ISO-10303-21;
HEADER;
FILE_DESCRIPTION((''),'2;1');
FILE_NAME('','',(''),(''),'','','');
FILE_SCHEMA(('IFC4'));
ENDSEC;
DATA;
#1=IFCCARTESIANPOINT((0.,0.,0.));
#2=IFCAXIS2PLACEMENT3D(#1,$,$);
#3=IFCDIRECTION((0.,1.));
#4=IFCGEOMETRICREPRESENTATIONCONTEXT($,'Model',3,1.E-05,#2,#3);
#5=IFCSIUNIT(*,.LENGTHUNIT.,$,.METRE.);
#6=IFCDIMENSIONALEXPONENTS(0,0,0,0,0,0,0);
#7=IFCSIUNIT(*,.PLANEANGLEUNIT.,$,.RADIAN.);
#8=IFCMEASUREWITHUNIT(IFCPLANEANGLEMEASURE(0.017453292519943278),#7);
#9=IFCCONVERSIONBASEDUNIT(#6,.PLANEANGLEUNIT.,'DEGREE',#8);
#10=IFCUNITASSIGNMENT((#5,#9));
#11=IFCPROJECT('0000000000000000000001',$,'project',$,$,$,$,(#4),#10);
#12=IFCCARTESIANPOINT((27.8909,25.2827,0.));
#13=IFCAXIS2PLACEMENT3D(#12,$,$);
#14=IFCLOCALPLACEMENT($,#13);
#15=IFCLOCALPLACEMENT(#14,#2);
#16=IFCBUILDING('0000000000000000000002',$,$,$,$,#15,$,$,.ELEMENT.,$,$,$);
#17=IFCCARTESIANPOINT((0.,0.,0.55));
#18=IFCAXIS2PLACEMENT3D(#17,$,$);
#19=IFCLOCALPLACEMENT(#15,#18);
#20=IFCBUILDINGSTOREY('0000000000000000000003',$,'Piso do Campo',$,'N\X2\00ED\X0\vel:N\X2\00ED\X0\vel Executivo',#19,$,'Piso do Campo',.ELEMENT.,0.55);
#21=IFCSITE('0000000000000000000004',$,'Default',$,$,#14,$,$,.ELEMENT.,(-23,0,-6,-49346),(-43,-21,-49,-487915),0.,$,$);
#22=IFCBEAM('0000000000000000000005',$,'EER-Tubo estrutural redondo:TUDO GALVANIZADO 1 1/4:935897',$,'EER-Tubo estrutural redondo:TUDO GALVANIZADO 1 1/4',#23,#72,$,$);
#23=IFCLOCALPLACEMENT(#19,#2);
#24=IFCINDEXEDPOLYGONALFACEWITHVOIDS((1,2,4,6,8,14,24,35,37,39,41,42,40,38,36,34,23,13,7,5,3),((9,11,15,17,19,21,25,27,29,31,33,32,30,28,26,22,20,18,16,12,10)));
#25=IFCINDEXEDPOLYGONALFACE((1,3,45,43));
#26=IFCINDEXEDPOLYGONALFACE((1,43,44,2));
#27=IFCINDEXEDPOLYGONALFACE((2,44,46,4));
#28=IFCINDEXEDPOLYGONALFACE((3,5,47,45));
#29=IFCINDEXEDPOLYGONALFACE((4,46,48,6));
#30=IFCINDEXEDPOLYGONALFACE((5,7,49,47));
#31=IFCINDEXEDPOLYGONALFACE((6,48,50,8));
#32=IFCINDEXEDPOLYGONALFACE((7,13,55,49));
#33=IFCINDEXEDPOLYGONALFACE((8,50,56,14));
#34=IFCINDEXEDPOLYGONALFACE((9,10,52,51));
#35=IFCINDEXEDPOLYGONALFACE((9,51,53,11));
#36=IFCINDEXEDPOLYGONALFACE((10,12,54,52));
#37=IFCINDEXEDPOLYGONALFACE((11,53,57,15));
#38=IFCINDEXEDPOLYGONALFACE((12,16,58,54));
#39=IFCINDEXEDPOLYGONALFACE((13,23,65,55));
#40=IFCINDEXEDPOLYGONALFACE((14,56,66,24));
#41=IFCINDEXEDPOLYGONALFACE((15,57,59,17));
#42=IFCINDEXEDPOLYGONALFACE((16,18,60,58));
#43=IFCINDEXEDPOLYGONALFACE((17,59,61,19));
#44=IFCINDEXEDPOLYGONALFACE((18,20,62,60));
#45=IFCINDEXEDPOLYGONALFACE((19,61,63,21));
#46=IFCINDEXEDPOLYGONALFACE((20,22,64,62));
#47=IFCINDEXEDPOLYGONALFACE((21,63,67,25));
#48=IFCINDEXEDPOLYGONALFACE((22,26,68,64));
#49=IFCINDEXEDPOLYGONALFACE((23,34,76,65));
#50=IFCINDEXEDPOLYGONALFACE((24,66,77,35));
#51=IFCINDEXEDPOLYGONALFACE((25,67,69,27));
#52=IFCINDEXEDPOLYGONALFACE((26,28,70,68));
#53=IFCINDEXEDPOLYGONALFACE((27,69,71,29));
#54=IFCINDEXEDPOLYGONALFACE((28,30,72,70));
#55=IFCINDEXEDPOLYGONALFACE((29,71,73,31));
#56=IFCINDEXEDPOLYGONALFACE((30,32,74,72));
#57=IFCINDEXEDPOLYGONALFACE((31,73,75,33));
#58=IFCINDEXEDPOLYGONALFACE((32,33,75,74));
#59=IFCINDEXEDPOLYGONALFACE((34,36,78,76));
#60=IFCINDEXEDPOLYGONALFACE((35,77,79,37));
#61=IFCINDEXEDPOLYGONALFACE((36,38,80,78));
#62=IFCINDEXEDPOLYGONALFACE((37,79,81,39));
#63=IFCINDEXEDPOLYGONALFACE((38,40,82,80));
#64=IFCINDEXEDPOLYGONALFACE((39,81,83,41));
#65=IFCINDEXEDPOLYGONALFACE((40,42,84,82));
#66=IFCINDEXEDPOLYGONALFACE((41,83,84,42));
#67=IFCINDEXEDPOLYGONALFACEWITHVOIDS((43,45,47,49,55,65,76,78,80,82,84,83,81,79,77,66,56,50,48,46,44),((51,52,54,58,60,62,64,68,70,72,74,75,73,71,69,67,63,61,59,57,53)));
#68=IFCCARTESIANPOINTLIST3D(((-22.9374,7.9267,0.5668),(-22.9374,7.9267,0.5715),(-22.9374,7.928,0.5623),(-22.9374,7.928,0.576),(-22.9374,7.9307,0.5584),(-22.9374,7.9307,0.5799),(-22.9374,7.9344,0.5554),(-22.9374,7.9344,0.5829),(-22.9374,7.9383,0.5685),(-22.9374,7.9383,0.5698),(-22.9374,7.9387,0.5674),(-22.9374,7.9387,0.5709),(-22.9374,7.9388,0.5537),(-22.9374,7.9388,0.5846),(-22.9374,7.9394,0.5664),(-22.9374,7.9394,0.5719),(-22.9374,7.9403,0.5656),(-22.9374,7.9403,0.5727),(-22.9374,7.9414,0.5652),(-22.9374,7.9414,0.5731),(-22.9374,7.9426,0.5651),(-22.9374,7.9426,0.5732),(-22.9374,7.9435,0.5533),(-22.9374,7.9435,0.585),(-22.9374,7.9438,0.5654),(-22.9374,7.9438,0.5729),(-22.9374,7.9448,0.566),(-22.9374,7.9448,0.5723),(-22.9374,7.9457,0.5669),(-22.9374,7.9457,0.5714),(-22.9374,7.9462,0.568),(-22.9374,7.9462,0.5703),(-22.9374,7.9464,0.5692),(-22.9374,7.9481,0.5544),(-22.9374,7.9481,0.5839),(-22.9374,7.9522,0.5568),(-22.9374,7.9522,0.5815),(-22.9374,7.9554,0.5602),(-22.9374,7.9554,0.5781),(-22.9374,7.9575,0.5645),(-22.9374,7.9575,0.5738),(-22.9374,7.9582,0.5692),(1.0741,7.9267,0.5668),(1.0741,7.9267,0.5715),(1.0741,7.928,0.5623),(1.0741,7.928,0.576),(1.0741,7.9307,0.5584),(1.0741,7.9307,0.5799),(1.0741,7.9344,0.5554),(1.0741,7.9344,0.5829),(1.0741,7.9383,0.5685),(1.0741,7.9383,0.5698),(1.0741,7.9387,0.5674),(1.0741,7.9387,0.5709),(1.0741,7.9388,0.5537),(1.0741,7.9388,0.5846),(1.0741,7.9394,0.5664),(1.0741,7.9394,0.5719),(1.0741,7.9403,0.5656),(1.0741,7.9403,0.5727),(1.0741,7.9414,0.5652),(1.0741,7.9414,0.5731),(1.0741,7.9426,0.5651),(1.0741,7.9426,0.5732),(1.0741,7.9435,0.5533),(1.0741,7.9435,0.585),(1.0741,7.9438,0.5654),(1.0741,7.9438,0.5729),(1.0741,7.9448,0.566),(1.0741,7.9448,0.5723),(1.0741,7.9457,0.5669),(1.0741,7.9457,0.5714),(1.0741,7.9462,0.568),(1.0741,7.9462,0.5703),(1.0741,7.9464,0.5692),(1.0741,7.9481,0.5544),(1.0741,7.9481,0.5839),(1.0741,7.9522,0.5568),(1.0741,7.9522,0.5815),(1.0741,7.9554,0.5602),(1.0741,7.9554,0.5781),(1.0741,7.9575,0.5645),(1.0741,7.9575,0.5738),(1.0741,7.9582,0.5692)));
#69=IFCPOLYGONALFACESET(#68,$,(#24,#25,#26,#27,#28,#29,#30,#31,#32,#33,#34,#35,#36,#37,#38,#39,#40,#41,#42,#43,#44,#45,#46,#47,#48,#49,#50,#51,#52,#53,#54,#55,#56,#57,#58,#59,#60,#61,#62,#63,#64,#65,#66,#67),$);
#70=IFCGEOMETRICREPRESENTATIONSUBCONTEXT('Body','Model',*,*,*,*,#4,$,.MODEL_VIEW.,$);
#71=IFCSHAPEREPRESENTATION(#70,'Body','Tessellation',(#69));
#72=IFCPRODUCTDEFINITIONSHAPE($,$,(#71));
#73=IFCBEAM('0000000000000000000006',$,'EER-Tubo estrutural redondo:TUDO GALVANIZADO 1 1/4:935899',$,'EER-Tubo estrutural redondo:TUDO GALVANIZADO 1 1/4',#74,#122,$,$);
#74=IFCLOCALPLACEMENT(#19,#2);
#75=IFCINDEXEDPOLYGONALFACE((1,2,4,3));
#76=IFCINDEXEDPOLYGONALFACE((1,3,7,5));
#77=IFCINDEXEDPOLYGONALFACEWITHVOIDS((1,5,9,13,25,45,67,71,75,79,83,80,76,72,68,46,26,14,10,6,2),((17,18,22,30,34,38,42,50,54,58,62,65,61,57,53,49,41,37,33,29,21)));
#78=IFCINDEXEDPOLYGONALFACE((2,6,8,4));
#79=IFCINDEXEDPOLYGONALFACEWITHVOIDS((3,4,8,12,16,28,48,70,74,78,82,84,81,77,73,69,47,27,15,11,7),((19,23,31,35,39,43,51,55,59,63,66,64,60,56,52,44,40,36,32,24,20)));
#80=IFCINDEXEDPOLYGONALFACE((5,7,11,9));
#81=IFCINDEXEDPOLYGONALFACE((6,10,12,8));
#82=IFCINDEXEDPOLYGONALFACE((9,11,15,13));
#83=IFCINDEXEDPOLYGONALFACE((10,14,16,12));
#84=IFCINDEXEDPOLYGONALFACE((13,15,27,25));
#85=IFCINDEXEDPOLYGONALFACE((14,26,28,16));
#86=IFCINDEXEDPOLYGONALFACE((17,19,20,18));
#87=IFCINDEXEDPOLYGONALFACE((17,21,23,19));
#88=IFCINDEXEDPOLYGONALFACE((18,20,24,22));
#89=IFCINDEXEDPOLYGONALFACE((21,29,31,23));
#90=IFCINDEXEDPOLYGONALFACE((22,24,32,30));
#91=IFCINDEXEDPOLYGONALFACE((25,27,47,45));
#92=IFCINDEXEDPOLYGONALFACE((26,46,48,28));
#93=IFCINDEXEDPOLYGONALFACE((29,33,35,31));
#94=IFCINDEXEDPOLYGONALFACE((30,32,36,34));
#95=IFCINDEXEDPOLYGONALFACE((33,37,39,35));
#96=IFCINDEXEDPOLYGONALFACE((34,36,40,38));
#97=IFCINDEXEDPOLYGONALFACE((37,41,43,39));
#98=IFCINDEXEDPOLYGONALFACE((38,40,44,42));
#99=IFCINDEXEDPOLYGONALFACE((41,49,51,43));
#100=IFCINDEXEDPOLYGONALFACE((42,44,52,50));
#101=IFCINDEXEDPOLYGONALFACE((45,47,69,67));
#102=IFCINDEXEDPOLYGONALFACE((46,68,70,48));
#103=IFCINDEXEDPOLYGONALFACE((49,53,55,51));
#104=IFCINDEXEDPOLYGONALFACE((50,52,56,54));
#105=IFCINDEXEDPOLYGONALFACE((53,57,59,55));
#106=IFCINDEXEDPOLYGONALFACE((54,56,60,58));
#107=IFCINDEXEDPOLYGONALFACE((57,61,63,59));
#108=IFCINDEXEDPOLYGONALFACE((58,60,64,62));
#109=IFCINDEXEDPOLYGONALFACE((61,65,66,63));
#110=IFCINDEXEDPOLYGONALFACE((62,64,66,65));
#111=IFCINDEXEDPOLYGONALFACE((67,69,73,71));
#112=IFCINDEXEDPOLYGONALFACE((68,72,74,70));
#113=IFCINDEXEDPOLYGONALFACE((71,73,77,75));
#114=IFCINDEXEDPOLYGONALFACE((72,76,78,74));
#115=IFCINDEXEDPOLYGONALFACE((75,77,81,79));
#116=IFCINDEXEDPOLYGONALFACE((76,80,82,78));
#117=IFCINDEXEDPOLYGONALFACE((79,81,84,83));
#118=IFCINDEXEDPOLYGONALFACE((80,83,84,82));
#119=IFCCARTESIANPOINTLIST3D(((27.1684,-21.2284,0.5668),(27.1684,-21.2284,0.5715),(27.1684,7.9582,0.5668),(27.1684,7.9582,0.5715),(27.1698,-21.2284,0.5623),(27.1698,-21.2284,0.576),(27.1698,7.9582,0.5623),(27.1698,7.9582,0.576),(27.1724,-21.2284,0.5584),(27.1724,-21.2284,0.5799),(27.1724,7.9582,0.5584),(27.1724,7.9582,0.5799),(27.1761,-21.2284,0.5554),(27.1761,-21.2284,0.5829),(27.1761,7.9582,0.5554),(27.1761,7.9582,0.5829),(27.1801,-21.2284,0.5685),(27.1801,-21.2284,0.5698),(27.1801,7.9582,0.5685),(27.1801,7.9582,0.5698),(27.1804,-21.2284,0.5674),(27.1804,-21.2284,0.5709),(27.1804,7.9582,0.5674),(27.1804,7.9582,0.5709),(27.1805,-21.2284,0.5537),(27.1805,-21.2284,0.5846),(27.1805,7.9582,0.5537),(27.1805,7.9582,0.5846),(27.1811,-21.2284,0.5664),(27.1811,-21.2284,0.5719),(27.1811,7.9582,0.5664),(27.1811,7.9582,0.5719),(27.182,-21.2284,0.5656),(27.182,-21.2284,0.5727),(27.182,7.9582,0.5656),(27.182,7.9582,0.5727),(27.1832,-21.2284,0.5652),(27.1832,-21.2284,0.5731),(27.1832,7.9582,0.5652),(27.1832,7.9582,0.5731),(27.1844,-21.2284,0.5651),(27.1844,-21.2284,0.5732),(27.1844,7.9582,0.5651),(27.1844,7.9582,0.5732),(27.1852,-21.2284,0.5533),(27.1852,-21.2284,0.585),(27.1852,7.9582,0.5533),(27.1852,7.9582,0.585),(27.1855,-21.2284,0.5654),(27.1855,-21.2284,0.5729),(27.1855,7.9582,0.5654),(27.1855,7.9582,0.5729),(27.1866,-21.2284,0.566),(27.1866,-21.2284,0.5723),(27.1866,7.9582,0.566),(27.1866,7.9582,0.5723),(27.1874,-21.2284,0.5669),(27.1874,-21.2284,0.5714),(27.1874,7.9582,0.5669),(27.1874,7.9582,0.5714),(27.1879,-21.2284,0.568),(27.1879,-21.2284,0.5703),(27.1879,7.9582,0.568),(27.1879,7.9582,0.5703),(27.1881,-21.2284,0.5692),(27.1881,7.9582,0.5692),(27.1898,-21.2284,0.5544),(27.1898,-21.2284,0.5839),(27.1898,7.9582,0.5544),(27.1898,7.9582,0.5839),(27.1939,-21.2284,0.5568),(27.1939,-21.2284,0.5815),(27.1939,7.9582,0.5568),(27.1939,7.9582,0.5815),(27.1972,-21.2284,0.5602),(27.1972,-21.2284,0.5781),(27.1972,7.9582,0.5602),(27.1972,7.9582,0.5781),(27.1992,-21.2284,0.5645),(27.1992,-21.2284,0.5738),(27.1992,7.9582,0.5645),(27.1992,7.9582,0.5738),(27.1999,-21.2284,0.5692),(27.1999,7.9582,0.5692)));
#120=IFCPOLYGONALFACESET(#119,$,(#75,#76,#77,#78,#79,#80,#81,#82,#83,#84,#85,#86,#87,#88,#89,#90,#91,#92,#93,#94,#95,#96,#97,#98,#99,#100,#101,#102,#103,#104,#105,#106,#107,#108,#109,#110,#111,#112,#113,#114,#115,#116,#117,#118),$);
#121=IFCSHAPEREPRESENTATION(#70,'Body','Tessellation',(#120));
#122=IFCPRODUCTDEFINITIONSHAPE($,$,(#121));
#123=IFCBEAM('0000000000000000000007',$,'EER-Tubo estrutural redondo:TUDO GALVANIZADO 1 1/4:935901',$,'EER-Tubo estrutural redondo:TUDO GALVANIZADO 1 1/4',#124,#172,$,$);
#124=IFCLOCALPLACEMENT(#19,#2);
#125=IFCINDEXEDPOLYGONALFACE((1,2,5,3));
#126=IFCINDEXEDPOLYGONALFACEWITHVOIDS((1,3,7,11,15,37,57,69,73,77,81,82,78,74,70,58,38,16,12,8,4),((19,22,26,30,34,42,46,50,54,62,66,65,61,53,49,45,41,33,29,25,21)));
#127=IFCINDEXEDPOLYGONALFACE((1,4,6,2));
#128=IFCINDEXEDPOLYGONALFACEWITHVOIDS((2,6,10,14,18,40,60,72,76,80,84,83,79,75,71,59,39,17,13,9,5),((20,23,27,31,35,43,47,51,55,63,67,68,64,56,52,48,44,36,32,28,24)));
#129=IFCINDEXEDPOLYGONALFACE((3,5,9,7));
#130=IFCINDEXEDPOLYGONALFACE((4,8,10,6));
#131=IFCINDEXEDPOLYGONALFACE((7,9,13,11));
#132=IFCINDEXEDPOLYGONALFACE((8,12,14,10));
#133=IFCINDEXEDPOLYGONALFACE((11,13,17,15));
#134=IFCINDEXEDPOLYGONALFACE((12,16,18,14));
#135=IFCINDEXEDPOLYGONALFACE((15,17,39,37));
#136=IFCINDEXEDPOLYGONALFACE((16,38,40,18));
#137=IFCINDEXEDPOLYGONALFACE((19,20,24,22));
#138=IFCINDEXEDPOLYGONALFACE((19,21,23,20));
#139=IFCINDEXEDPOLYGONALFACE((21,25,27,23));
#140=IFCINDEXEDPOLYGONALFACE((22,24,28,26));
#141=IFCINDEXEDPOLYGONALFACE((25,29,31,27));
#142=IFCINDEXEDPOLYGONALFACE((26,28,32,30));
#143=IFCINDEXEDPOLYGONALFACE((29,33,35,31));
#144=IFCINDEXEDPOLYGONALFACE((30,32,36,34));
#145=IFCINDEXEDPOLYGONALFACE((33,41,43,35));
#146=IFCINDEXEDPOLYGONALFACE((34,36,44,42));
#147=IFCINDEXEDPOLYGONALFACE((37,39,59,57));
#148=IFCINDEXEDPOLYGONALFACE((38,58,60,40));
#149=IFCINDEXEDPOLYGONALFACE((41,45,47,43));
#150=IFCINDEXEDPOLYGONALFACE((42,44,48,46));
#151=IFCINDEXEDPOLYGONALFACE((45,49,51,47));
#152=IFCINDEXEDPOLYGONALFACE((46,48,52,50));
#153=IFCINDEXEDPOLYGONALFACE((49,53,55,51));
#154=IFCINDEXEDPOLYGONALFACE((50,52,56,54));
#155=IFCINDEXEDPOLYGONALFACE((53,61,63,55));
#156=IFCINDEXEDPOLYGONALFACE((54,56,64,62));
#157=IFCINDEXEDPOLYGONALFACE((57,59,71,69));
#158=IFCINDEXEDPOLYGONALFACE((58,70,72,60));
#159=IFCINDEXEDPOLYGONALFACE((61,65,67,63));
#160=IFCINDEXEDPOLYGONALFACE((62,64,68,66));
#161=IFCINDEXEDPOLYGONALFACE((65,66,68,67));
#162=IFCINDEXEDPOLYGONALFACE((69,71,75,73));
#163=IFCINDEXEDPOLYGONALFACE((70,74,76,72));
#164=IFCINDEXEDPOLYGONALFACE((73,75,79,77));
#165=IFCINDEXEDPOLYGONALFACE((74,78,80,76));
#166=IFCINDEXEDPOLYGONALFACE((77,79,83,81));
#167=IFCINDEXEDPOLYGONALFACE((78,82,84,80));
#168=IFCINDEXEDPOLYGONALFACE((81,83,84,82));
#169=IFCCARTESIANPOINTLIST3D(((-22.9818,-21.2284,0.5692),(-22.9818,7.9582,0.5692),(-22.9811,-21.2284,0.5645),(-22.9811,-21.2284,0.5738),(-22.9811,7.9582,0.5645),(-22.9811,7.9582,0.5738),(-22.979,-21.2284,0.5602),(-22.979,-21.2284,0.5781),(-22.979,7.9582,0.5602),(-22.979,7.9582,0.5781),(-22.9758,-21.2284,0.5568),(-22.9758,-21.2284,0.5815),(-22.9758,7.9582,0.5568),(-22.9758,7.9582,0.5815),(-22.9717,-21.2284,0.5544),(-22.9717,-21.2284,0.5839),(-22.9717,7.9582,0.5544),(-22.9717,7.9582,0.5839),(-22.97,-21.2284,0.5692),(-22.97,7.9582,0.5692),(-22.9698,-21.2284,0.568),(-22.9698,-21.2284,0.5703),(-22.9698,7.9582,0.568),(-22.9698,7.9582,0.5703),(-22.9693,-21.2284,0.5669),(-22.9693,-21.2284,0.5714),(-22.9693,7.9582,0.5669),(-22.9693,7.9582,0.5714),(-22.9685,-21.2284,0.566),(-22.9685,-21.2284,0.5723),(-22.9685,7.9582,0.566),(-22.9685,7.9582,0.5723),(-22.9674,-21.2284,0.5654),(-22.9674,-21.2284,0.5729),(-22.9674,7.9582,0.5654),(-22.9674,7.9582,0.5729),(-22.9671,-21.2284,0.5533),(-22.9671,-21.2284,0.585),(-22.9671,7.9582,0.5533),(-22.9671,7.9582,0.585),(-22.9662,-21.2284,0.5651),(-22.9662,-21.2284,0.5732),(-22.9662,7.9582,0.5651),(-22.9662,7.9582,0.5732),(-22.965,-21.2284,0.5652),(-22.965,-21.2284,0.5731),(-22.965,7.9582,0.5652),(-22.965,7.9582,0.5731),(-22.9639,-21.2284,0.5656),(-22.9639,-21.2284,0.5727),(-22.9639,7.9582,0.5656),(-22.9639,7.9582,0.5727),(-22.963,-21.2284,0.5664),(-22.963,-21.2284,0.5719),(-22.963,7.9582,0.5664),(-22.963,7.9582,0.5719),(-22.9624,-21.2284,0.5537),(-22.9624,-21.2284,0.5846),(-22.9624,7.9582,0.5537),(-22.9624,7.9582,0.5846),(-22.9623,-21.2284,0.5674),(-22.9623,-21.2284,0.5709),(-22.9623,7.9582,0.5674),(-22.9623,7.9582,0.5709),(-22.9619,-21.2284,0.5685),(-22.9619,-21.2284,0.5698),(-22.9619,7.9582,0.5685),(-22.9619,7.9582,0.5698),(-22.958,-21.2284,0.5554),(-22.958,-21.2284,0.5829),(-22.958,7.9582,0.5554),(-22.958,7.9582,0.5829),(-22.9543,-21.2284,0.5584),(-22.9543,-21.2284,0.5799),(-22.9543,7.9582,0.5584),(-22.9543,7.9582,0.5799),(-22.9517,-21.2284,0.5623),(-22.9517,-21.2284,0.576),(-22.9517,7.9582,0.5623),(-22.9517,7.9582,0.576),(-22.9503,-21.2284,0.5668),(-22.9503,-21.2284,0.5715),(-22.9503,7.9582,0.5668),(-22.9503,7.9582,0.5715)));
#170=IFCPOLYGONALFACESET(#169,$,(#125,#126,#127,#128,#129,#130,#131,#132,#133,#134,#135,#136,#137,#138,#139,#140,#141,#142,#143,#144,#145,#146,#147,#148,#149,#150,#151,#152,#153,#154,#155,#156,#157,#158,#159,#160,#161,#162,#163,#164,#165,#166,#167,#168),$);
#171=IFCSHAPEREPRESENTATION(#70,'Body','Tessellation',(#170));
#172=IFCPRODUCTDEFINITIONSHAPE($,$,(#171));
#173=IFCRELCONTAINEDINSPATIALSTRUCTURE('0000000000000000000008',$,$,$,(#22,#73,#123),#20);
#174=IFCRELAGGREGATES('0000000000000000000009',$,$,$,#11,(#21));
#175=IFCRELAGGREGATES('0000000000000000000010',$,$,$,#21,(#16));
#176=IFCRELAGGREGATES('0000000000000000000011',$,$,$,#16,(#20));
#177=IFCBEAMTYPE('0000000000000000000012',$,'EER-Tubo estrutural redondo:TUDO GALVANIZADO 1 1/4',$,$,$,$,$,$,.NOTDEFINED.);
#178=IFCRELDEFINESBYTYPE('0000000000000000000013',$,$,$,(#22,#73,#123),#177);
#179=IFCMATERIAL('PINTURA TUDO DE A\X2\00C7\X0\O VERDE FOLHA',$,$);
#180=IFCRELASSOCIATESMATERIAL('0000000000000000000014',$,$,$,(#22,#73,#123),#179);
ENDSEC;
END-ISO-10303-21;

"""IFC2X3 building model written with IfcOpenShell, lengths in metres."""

from ifc_helpers import new_model, entity, si_unit, converted_unit, direction, frame, origin, origin_2d_with_axis, place, context, subcontext, project, spatial, hollow_circle, extrude, material, type_object, element, save


model = new_model("IFC2X3")

# Units and contexts
model_context = context("Model", 3, precision=1e-05, world=origin(), true_north=direction((0.0, 1.0)))
body_context = subcontext(model_context, "Body", "Model", "MODEL_VIEW")
ifc_project = project(units=[si_unit("LENGTHUNIT", "METRE"), converted_unit("PLANEANGLEUNIT", "DEGREE", entity("IfcPlaneAngleMeasure", 0.017453292519943278), si_unit("PLANEANGLEUNIT", "RADIAN"), dimensions=[0, 0, 0, 0, 0, 0, 0])], contexts=[model_context])

# Site, building, storey
site_placement = place(None, frame((27.8909, 25.2827, 0.0)))
site = spatial("IfcSite", under=ifc_project, at=site_placement, Name="Default", CompositionType="ELEMENT", RefLatitude=(-23, 0, -6, -49346), RefLongitude=(-43, -21, -49, -487915), RefElevation=0.0)
building_placement = place(site_placement, origin())
building = spatial("IfcBuilding", under=site, at=building_placement, CompositionType="ELEMENT")
storey_placement = place(building_placement, frame((0.0, 0.0, 0.55)))
storey = spatial("IfcBuildingStorey", under=building, at=storey_placement, Name="Piso do Campo", ObjectType="Nível:Nível Executivo", LongName="Piso do Campo", CompositionType="ELEMENT", Elevation=0.55)

# Beams
ifc_material = material(Name="PINTURA TUDO DE AÇO VERDE FOLHA")
beam_type = type_object("IfcBeamType", Name="EER-Tubo estrutural redondo:TUDO GALVANIZADO 1 1/4", PredefinedType="NOTDEFINED")
beam_1_placement = place(storey_placement, frame((-22.9659, 7.9423, 0.585)))
element("IfcBeam", 1, at=beam_1_placement, inside=storey, type_object=beam_type, material=ifc_material, Name="EER-Tubo estrutural redondo:TUDO GALVANIZADO 1 1/4:935897", ObjectType="EER-Tubo estrutural redondo:TUDO GALVANIZADO 1 1/4", context=body_context, shape_type="SweptSolid", body=[
    extrude(hollow_circle(Radius=0.0159, WallThickness=0.0118, at=origin_2d_with_axis()), frame((0.0286, 0.0, -0.0159), z_axis=(1.0, 0.0, 0.0), x_axis=(0.0, 1.0, 0.0)), (0.0, 0.0, 1.0), 24.0114),
])
beam_2_placement = place(storey_placement, frame((27.1841, 7.9423, 0.585), z_axis=(0.0, 0.0, 1.0), x_axis=(0.0, -1.0, 0.0)))
element("IfcBeam", 2, at=beam_2_placement, inside=storey, type_object=beam_type, material=ifc_material, Name="EER-Tubo estrutural redondo:TUDO GALVANIZADO 1 1/4:935899", ObjectType="EER-Tubo estrutural redondo:TUDO GALVANIZADO 1 1/4", context=body_context, shape_type="SweptSolid", body=[
    extrude(hollow_circle(Radius=0.0159, WallThickness=0.0118, at=origin_2d_with_axis()), frame((-0.0159, 0.0, -0.0159), z_axis=(1.0, 0.0, 0.0), x_axis=(0.0, 1.0, 0.0)), (0.0, 0.0, 1.0), 29.1865),
])
beam_3_placement = place(storey_placement, frame((-22.9659, -21.2073, 0.585), z_axis=(0.0, 0.0, 1.0), x_axis=(0.0, 1.0, 0.0)))
element("IfcBeam", 3, at=beam_3_placement, inside=storey, type_object=beam_type, material=ifc_material, Name="EER-Tubo estrutural redondo:TUDO GALVANIZADO 1 1/4:935901", ObjectType="EER-Tubo estrutural redondo:TUDO GALVANIZADO 1 1/4", context=body_context, shape_type="SweptSolid", body=[
    extrude(hollow_circle(Radius=0.0159, WallThickness=0.0118, at=origin_2d_with_axis()), frame((-0.021, 0.0, -0.0159), z_axis=(1.0, 0.0, 0.0), x_axis=(0.0, 1.0, 0.0)), (0.0, 0.0, 1.0), 29.1865),
])

save(model, "model.ifc")
